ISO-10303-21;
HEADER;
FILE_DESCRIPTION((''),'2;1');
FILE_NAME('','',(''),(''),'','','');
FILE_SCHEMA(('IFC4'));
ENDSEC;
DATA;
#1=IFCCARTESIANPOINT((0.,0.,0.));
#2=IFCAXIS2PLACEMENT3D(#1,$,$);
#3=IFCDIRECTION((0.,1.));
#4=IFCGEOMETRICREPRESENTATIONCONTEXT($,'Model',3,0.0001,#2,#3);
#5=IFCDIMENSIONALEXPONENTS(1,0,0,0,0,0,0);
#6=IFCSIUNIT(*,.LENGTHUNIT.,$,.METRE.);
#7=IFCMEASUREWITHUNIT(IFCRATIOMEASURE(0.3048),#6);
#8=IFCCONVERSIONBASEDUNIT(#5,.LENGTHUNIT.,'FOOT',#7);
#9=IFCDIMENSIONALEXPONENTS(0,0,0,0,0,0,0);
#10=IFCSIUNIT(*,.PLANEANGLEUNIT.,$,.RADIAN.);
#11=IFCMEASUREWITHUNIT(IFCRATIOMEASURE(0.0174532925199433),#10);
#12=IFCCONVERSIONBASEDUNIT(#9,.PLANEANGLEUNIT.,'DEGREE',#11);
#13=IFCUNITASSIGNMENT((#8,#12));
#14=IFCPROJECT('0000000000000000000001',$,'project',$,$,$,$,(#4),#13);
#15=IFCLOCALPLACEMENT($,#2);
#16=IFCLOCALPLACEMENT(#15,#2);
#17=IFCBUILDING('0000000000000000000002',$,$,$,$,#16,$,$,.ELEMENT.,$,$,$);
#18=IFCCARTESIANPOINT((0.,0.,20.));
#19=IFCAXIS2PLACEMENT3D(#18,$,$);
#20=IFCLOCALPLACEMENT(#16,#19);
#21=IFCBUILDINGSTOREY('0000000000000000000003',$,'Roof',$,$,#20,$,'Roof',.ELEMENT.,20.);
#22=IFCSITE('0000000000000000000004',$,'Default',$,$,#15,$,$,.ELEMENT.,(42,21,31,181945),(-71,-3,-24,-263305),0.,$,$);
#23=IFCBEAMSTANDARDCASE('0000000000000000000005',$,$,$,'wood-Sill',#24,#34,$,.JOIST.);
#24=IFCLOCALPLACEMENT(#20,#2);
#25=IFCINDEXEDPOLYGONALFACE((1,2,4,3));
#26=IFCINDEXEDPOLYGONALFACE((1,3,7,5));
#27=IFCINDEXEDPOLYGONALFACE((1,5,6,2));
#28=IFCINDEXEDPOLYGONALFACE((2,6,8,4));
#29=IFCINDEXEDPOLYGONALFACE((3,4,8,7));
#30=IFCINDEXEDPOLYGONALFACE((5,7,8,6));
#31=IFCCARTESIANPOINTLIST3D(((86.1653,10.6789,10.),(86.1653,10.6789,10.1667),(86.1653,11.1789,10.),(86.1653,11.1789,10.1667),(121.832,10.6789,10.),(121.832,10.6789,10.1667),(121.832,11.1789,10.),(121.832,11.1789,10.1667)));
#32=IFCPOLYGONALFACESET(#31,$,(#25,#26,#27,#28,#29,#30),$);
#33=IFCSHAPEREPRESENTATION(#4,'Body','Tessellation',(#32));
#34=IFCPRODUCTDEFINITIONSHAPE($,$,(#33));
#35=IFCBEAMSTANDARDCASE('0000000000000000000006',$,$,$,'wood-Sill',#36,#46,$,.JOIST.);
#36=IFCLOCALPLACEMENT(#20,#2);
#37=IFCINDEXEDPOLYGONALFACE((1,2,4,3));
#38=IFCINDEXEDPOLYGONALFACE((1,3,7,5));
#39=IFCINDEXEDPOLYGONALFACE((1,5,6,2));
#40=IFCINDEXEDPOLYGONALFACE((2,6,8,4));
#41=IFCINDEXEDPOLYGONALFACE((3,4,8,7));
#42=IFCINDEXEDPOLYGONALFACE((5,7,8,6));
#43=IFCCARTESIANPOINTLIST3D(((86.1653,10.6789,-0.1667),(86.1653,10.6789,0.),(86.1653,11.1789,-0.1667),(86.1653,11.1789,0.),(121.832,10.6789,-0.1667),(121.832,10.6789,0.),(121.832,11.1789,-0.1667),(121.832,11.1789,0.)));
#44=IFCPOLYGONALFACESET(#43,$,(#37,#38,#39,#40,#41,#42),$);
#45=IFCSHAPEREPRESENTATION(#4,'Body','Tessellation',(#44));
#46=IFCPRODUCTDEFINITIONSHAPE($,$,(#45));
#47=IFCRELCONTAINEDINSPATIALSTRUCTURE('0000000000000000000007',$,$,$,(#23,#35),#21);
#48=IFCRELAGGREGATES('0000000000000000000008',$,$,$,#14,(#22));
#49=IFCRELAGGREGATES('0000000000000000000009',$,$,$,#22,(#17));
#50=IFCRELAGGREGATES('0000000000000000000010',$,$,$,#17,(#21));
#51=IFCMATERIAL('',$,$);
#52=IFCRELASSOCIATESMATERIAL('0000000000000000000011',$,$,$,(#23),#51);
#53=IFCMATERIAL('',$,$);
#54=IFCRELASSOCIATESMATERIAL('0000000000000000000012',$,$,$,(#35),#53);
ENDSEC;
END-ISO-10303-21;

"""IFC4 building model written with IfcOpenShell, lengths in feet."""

from ifc_helpers import new_model, entity, si_unit, converted_unit, direction, frame, origin, place, context, project, spatial, rectangle, extrude, material, element, save


model = new_model("IFC4")

# Units and contexts
model_context = context("Model", 3, precision=0.0001, world=origin(), true_north=direction((0.0, 1.0)))
ifc_project = project(units=[converted_unit("LENGTHUNIT", "FOOT", entity("IfcRatioMeasure", 0.3048), si_unit("LENGTHUNIT", "METRE"), dimensions=[1, 0, 0, 0, 0, 0, 0]), converted_unit("PLANEANGLEUNIT", "DEGREE", entity("IfcRatioMeasure", 0.0174532925199433), si_unit("PLANEANGLEUNIT", "RADIAN"), dimensions=[0, 0, 0, 0, 0, 0, 0])], contexts=[model_context])

# Site, building, storey
site_placement = place(None, origin())
site = spatial("IfcSite", under=ifc_project, at=site_placement, Name="Default", CompositionType="ELEMENT", RefLatitude=(42, 21, 31, 181945), RefLongitude=(-71, -3, -24, -263305), RefElevation=0.0)
building_placement = place(site_placement, origin())
building = spatial("IfcBuilding", under=site, at=building_placement, CompositionType="ELEMENT")
storey_placement = place(building_placement, frame((0.0, 0.0, 20.0)))
storey = spatial("IfcBuildingStorey", under=building, at=storey_placement, Name="Roof", LongName="Roof", CompositionType="ELEMENT", Elevation=20.0)

# Shared definitions
placement_1 = place(storey_placement, frame((103.9986, -6.9045, 0.0), z_axis=(0.0, 0.0, 1.0), x_axis=(0.0, 1.0, 0.0)))

# Beams
ifc_material_1 = material(Name="")
beam_1_placement = place(placement_1, frame((17.8334, 0.0, 10.0), z_axis=(0.0, 0.0, 1.0), x_axis=(0.0, 1.0, 0.0)))
element("IfcBeamStandardCase", 1, at=beam_1_placement, inside=storey, material=ifc_material_1, ObjectType="wood-Sill", PredefinedType="JOIST", context=model_context, shape_type="SweptSolid", body=[
    extrude(rectangle(XDim=35.6667, YDim=0.5), origin(), (0.0, 0.0, 1.0), 0.1667),
])
ifc_material_2 = material(Name="")
beam_2_placement = place(placement_1, frame((17.8334, 0.0, -0.1667), z_axis=(0.0, 0.0, 1.0), x_axis=(0.0, 1.0, 0.0)))
element("IfcBeamStandardCase", 2, at=beam_2_placement, inside=storey, material=ifc_material_2, ObjectType="wood-Sill", PredefinedType="JOIST", context=model_context, shape_type="SweptSolid", body=[
    extrude(rectangle(XDim=35.6667, YDim=0.5), origin(), (0.0, 0.0, 1.0), 0.1667),
])

save(model, "model.ifc")
